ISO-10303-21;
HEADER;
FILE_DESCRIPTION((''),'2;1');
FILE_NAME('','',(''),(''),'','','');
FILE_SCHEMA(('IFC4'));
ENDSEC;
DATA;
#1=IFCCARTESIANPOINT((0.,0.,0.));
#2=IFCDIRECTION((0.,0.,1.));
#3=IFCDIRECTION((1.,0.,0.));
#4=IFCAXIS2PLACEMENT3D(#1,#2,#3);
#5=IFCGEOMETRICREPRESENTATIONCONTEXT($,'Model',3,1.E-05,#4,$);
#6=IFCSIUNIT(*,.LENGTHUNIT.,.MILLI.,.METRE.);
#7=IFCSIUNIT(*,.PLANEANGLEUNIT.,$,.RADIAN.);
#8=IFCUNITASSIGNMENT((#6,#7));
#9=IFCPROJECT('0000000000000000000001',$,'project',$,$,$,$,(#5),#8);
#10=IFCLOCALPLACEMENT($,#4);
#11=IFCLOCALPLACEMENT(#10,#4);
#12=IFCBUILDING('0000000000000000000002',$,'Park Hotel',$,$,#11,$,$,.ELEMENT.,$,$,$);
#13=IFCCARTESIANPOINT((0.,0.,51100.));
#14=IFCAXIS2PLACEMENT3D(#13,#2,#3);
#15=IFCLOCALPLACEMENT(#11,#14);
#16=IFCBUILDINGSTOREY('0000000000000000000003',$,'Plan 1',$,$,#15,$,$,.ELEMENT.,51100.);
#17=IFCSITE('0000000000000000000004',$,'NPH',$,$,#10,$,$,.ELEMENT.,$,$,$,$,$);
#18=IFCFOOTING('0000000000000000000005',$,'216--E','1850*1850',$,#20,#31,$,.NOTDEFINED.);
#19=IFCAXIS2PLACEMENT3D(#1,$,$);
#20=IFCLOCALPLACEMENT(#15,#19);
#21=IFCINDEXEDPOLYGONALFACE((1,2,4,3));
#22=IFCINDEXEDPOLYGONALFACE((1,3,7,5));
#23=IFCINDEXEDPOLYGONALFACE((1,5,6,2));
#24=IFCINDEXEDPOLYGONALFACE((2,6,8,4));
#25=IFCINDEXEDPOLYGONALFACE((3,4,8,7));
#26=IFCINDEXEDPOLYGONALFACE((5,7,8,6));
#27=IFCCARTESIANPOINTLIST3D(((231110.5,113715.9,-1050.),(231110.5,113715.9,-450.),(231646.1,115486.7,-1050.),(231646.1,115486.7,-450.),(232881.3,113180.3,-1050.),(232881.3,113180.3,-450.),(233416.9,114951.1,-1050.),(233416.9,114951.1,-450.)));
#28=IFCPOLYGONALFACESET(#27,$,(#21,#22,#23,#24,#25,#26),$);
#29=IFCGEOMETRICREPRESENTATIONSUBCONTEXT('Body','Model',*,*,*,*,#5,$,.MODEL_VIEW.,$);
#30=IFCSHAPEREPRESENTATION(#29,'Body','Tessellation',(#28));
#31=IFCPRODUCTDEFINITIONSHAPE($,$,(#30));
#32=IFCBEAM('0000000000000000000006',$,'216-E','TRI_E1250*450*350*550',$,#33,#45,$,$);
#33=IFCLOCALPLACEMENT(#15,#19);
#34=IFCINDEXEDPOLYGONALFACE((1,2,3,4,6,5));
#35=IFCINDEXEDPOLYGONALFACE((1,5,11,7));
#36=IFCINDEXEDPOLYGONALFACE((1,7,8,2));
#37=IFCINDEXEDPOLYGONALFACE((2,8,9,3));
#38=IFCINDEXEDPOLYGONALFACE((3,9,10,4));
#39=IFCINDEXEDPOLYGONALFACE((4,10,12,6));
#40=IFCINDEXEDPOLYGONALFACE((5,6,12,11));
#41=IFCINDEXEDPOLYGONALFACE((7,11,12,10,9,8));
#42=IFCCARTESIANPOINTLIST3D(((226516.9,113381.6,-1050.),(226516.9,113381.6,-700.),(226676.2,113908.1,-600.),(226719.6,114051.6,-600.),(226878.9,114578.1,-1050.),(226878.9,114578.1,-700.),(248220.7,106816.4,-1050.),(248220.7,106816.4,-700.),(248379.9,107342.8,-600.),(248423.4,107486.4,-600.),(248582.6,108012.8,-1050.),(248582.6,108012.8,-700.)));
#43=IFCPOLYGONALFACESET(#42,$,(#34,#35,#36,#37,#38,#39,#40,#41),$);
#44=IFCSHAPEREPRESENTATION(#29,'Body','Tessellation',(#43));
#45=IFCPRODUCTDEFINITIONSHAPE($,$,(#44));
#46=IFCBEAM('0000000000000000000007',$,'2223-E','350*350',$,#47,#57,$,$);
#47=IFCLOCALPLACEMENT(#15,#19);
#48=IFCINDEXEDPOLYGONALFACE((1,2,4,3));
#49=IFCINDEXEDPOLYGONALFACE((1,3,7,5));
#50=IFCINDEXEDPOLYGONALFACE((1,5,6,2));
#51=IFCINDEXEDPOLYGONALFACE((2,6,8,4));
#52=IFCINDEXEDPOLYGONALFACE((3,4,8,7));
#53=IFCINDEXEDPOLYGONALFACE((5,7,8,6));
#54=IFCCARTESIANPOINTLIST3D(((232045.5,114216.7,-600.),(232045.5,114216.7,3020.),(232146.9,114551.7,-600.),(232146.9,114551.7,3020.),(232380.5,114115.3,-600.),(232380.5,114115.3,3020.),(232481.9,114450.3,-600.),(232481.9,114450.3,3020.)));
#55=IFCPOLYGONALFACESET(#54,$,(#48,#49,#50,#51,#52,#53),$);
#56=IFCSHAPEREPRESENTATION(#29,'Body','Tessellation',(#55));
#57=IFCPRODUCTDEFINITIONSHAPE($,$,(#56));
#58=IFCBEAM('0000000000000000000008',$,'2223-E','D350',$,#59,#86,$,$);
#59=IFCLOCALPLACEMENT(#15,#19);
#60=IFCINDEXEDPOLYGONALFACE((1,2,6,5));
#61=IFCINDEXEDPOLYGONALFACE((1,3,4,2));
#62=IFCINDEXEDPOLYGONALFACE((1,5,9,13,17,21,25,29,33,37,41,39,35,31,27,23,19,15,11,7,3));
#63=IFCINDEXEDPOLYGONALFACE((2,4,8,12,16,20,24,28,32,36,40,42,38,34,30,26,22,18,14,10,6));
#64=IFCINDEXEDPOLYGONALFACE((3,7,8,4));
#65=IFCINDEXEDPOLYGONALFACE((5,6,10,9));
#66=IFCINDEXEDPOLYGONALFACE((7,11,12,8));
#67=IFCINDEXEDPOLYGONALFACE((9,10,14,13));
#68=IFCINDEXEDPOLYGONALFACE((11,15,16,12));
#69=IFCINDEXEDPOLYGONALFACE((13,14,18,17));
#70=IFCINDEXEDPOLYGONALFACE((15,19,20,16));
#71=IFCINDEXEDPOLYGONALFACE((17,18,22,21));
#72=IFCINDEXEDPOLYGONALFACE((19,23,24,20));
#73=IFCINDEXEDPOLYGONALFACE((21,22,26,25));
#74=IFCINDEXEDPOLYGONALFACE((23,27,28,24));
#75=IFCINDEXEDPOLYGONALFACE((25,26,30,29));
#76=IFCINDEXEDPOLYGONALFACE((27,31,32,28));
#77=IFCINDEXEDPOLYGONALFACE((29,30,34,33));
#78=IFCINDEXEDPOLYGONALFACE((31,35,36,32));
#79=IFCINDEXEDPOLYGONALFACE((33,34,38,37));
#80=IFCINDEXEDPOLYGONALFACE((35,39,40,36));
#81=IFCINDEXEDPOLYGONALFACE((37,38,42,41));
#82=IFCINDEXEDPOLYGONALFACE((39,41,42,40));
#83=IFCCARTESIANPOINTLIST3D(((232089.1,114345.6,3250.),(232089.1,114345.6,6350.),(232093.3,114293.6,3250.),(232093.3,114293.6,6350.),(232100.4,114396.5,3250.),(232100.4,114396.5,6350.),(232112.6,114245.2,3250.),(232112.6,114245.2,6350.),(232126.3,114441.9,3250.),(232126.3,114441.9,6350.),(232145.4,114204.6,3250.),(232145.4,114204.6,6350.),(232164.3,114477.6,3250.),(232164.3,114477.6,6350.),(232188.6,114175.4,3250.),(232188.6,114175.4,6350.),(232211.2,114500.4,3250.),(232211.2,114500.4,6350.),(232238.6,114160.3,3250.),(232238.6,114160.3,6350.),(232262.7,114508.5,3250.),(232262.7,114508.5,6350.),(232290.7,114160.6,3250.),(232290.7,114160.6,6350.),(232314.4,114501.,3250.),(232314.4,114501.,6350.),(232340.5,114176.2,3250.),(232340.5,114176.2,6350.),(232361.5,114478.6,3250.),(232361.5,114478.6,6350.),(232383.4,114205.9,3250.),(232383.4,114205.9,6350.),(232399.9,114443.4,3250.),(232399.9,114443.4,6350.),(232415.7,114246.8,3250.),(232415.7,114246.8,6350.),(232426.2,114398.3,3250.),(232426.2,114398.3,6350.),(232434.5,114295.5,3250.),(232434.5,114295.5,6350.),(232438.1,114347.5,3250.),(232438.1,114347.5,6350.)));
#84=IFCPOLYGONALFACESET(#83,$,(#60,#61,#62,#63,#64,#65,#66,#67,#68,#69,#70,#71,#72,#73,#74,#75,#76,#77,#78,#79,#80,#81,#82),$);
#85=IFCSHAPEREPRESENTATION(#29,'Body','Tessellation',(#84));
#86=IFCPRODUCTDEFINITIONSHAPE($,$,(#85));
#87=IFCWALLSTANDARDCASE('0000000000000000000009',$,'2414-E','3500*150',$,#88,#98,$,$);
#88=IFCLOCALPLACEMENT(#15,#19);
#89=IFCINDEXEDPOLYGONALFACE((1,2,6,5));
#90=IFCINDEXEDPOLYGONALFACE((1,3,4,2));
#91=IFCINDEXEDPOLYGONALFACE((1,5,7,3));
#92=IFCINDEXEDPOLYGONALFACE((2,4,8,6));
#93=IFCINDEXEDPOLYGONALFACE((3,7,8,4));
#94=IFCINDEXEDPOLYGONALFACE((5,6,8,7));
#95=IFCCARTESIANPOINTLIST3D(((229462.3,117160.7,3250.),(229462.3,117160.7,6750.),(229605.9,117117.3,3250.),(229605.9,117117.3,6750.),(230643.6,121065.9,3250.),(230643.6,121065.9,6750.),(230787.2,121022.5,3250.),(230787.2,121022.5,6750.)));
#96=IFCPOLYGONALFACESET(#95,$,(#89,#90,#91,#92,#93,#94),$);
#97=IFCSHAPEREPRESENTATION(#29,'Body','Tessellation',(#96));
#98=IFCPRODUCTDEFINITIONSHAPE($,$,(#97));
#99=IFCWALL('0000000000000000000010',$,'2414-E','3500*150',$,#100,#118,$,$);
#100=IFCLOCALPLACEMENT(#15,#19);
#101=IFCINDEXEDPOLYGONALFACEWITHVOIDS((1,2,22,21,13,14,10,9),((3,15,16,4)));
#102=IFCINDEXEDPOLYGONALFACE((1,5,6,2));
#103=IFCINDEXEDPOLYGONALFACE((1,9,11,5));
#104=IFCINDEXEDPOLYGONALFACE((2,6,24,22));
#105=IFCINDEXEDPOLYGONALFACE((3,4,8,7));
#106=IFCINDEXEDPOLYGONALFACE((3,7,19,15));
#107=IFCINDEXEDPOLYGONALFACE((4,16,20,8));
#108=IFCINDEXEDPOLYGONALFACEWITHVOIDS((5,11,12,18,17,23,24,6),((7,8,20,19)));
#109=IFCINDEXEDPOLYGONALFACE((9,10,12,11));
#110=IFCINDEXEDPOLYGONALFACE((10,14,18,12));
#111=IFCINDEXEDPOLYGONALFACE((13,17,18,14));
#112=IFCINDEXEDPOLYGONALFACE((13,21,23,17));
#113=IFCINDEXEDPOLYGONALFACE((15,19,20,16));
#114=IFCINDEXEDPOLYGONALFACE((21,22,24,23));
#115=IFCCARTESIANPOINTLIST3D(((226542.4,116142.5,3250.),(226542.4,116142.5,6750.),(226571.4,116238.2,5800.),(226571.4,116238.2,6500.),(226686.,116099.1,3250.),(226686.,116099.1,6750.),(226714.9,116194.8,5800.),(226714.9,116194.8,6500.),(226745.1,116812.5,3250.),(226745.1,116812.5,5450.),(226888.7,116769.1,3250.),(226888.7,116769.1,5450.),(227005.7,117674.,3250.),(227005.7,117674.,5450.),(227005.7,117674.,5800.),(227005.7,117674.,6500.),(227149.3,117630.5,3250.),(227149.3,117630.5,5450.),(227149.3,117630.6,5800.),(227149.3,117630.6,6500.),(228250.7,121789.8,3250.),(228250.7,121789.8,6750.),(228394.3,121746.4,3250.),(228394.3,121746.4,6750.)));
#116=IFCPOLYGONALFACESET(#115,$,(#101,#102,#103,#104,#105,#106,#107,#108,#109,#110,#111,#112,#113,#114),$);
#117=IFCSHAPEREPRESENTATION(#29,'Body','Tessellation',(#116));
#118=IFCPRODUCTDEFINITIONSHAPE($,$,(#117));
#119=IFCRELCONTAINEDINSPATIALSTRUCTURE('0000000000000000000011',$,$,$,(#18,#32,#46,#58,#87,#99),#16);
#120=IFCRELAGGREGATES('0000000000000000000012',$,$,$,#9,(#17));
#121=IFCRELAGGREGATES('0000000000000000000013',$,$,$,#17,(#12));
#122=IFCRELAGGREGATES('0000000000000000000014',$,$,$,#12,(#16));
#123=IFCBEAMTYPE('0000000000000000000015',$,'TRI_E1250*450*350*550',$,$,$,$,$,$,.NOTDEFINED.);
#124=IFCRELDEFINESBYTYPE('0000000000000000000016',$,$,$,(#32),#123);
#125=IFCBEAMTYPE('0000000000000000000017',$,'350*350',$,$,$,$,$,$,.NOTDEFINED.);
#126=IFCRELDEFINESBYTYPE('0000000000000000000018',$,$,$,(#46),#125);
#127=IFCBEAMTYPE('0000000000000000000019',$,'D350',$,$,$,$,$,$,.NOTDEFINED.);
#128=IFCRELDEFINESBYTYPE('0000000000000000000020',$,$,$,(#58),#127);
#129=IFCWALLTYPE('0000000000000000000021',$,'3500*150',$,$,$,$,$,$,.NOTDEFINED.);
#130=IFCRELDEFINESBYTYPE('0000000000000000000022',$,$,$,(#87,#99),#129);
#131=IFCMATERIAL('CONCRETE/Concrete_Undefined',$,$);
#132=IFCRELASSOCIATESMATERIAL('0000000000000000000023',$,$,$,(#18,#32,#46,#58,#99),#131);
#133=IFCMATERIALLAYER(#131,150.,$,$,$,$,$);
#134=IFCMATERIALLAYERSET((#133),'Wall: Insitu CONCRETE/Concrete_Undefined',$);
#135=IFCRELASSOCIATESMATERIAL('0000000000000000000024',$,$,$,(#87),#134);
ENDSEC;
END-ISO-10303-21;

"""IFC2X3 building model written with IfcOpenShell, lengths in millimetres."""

from ifc_helpers import new_model, si_unit, frame, frame_2d, origin_with_axes, origin_2d_with_axis, place, context, subcontext, project, spatial, polyline, rectangle, circle, outline, extrude, boolean, material, layer, layer_set, layer_usage, type_object, element, save


model = new_model("IFC2X3")

# Units and contexts
model_context = context("Model", 3, precision=1e-05, world=origin_with_axes())
body_context = subcontext(model_context, "Body", "Model", "MODEL_VIEW")
ifc_project = project(units=[si_unit("LENGTHUNIT", "METRE", prefix="MILLI"), si_unit("PLANEANGLEUNIT", "RADIAN")], contexts=[model_context])

# Site, building, storey
site_placement = place(None, origin_with_axes())
site = spatial("IfcSite", under=ifc_project, at=site_placement, Name="NPH", CompositionType="ELEMENT")
building_placement = place(site_placement, origin_with_axes())
building = spatial("IfcBuilding", under=site, at=building_placement, Name="Park Hotel", CompositionType="ELEMENT")
storey_placement = place(building_placement, frame((0.0, 0.0, 51100.0), z_axis=(0.0, 0.0, 1.0), x_axis=(1.0, 0.0, 0.0)))
storey = spatial("IfcBuildingStorey", under=building, at=storey_placement, Name="Plan 1", CompositionType="ELEMENT", Elevation=51100.0)

# Footing
ifc_material_1 = material(Name="CONCRETE/Concrete_Undefined")
footing_placement = place(storey_placement, frame((232263.7, 114333.5, -1050.0), z_axis=(0.289538, 0.957167, 0.0), x_axis=(0.0, 0.0, 1.0)))
element("IfcFooting", 1, at=footing_placement, inside=storey, material=ifc_material_1, Name="216--E", Description="1850*1850", PredefinedType="NOTDEFINED", context=body_context, shape_type="SweptSolid", body=[
    extrude(rectangle(XDim=1850.0, YDim=1850.0, at=origin_2d_with_axis()), frame((600.0, 0.0, 0.0), z_axis=(-1.0, 0.0, 0.0), x_axis=(0.0, -1.0, 0.0)), (0.0, 0.0, 1.0), 600.0),
])

# Beams
beam_type_1 = type_object("IfcBeamType", Name="TRI_E1250*450*350*550", PredefinedType="NOTDEFINED")
beam_1_placement = place(storey_placement, frame((226697.9, 113979.9, -825.0), z_axis=(0.0, 0.0, 1.0), x_axis=(0.957167, -0.289538, 0.0)))
element("IfcBeam", 2, at=beam_1_placement, inside=storey, type_object=beam_type_1, material=ifc_material_1, Name="216-E", Description="TRI_E1250*450*350*550", context=body_context, shape_type="SweptSolid", body=[
    extrude(outline(polyline([(625.0, -225.0), (-625.0, -225.0), (-625.0, 125.0), (-75.0, 225.0), (75.0, 225.0), (625.0, 125.0), (625.0, -225.0)])), frame((22675.0, 0.0, 0.0), z_axis=(-1.0, 0.0, 0.0), x_axis=(0.0, -1.0, 0.0)), (0.0, 0.0, 1.0), 22675.0),
])
beam_type_2 = type_object("IfcBeamType", Name="350*350", PredefinedType="NOTDEFINED")
beam_2_placement = place(storey_placement, frame((232263.7, 114333.5, -600.0), z_axis=(0.957167, -0.289538, 0.0), x_axis=(0.0, 0.0, 1.0)))
element("IfcBeam", 3, at=beam_2_placement, inside=storey, type_object=beam_type_2, material=ifc_material_1, Name="2223-E", Description="350*350", context=body_context, shape_type="SweptSolid", body=[
    extrude(rectangle(XDim=350.0, YDim=350.0, at=origin_2d_with_axis()), frame((3620.0, 0.0, 0.0), z_axis=(-1.0, 0.0, 0.0), x_axis=(0.0, -1.0, 0.0)), (0.0, 0.0, 1.0), 3620.0),
])
beam_type_3 = type_object("IfcBeamType", Name="D350", PredefinedType="NOTDEFINED")
beam_3_placement = place(storey_placement, frame((232263.7, 114333.5, 3250.0), z_axis=(0.957167, -0.289538, 0.0), x_axis=(0.0, 0.0, 1.0)))
element("IfcBeam", 4, at=beam_3_placement, inside=storey, type_object=beam_type_3, material=ifc_material_1, Name="2223-E", Description="D350", context=body_context, shape_type="SweptSolid", body=[
    extrude(circle(Radius=175.0, at=origin_2d_with_axis()), frame((3100.0, 0.0, 0.0), z_axis=(-1.0, 0.0, 0.0), x_axis=(0.0, -1.0, 0.0)), (0.0, 0.0, 1.0), 3100.0),
])

# Walls
ifc_layer_1 = layer(ifc_material_1, 150.0)
ifc_layer_set_1 = layer_set([ifc_layer_1], Name="Wall: Insitu CONCRETE/Concrete_Undefined")
ifc_layer_usage_1 = layer_usage(ifc_layer_set_1, "AXIS2", "POSITIVE", -75.0)
wall_type_1 = type_object("IfcWallType", Name="3500*150", PredefinedType="NOTDEFINED")
wall_1_placement = place(storey_placement, frame((229534.1, 117139.0, 3250.0), z_axis=(0.0, 0.0, 1.0), x_axis=(0.289539, 0.957166, 0.0)))
element("IfcWallStandardCase", 5, at=wall_1_placement, inside=storey, type_object=wall_type_1, material=ifc_layer_usage_1, Name="2414-E", Description="3500*150", context=body_context, shape_type="SweptSolid", body=[
    extrude(rectangle(XDim=4080.0, YDim=150.0, at=frame_2d((0.0, 2040.0), x_axis=(0.0, -1.0))), frame((0.0, 0.0, 0.0), z_axis=(0.0, 0.0, 1.0), x_axis=(0.0, -1.0, 0.0)), (0.0, 0.0, 1.0), 3500.0),
])
wall_2_placement = place(storey_placement, frame((226614.2, 116120.8, 3250.0), z_axis=(0.0, 0.0, 1.0), x_axis=(0.289539, 0.957166, 0.0)))
element("IfcWall", 6, at=wall_2_placement, inside=storey, type_object=wall_type_1, material=ifc_material_1, Name="2414-E", Description="3500*150", context=body_context, shape_type="CSG", body=[
    boolean("DIFFERENCE", boolean("DIFFERENCE", extrude(rectangle(XDim=5900.0, YDim=150.0, at=frame_2d((0.0, 2950.0), x_axis=(0.0, -1.0))), frame((0.0, 0.0, 0.0), z_axis=(0.0, 0.0, 1.0), x_axis=(0.0, -1.0, 0.0)), (0.0, 0.0, 1.0), 3500.0), extrude(rectangle(XDim=1500.0, YDim=200.0, at=frame_2d((0.0, 750.0), x_axis=(0.0, -1.0))), frame((1600.0, -25.0, 2550.0), z_axis=(0.0, 0.0, 1.0), x_axis=(0.0, 1.0, 0.0)), (0.0, 0.0, 1.0), 700.0)), extrude(rectangle(XDim=900.0, YDim=150.0, at=frame_2d((0.0, 450.0), x_axis=(0.0, -1.0))), frame((700.0, 0.0, 0.0), z_axis=(0.0, 0.0, 1.0), x_axis=(-0.000003, -1.0, 0.0)), (0.0, 0.0, 1.0), 2200.0)),
])

save(model, "model.ifc")
